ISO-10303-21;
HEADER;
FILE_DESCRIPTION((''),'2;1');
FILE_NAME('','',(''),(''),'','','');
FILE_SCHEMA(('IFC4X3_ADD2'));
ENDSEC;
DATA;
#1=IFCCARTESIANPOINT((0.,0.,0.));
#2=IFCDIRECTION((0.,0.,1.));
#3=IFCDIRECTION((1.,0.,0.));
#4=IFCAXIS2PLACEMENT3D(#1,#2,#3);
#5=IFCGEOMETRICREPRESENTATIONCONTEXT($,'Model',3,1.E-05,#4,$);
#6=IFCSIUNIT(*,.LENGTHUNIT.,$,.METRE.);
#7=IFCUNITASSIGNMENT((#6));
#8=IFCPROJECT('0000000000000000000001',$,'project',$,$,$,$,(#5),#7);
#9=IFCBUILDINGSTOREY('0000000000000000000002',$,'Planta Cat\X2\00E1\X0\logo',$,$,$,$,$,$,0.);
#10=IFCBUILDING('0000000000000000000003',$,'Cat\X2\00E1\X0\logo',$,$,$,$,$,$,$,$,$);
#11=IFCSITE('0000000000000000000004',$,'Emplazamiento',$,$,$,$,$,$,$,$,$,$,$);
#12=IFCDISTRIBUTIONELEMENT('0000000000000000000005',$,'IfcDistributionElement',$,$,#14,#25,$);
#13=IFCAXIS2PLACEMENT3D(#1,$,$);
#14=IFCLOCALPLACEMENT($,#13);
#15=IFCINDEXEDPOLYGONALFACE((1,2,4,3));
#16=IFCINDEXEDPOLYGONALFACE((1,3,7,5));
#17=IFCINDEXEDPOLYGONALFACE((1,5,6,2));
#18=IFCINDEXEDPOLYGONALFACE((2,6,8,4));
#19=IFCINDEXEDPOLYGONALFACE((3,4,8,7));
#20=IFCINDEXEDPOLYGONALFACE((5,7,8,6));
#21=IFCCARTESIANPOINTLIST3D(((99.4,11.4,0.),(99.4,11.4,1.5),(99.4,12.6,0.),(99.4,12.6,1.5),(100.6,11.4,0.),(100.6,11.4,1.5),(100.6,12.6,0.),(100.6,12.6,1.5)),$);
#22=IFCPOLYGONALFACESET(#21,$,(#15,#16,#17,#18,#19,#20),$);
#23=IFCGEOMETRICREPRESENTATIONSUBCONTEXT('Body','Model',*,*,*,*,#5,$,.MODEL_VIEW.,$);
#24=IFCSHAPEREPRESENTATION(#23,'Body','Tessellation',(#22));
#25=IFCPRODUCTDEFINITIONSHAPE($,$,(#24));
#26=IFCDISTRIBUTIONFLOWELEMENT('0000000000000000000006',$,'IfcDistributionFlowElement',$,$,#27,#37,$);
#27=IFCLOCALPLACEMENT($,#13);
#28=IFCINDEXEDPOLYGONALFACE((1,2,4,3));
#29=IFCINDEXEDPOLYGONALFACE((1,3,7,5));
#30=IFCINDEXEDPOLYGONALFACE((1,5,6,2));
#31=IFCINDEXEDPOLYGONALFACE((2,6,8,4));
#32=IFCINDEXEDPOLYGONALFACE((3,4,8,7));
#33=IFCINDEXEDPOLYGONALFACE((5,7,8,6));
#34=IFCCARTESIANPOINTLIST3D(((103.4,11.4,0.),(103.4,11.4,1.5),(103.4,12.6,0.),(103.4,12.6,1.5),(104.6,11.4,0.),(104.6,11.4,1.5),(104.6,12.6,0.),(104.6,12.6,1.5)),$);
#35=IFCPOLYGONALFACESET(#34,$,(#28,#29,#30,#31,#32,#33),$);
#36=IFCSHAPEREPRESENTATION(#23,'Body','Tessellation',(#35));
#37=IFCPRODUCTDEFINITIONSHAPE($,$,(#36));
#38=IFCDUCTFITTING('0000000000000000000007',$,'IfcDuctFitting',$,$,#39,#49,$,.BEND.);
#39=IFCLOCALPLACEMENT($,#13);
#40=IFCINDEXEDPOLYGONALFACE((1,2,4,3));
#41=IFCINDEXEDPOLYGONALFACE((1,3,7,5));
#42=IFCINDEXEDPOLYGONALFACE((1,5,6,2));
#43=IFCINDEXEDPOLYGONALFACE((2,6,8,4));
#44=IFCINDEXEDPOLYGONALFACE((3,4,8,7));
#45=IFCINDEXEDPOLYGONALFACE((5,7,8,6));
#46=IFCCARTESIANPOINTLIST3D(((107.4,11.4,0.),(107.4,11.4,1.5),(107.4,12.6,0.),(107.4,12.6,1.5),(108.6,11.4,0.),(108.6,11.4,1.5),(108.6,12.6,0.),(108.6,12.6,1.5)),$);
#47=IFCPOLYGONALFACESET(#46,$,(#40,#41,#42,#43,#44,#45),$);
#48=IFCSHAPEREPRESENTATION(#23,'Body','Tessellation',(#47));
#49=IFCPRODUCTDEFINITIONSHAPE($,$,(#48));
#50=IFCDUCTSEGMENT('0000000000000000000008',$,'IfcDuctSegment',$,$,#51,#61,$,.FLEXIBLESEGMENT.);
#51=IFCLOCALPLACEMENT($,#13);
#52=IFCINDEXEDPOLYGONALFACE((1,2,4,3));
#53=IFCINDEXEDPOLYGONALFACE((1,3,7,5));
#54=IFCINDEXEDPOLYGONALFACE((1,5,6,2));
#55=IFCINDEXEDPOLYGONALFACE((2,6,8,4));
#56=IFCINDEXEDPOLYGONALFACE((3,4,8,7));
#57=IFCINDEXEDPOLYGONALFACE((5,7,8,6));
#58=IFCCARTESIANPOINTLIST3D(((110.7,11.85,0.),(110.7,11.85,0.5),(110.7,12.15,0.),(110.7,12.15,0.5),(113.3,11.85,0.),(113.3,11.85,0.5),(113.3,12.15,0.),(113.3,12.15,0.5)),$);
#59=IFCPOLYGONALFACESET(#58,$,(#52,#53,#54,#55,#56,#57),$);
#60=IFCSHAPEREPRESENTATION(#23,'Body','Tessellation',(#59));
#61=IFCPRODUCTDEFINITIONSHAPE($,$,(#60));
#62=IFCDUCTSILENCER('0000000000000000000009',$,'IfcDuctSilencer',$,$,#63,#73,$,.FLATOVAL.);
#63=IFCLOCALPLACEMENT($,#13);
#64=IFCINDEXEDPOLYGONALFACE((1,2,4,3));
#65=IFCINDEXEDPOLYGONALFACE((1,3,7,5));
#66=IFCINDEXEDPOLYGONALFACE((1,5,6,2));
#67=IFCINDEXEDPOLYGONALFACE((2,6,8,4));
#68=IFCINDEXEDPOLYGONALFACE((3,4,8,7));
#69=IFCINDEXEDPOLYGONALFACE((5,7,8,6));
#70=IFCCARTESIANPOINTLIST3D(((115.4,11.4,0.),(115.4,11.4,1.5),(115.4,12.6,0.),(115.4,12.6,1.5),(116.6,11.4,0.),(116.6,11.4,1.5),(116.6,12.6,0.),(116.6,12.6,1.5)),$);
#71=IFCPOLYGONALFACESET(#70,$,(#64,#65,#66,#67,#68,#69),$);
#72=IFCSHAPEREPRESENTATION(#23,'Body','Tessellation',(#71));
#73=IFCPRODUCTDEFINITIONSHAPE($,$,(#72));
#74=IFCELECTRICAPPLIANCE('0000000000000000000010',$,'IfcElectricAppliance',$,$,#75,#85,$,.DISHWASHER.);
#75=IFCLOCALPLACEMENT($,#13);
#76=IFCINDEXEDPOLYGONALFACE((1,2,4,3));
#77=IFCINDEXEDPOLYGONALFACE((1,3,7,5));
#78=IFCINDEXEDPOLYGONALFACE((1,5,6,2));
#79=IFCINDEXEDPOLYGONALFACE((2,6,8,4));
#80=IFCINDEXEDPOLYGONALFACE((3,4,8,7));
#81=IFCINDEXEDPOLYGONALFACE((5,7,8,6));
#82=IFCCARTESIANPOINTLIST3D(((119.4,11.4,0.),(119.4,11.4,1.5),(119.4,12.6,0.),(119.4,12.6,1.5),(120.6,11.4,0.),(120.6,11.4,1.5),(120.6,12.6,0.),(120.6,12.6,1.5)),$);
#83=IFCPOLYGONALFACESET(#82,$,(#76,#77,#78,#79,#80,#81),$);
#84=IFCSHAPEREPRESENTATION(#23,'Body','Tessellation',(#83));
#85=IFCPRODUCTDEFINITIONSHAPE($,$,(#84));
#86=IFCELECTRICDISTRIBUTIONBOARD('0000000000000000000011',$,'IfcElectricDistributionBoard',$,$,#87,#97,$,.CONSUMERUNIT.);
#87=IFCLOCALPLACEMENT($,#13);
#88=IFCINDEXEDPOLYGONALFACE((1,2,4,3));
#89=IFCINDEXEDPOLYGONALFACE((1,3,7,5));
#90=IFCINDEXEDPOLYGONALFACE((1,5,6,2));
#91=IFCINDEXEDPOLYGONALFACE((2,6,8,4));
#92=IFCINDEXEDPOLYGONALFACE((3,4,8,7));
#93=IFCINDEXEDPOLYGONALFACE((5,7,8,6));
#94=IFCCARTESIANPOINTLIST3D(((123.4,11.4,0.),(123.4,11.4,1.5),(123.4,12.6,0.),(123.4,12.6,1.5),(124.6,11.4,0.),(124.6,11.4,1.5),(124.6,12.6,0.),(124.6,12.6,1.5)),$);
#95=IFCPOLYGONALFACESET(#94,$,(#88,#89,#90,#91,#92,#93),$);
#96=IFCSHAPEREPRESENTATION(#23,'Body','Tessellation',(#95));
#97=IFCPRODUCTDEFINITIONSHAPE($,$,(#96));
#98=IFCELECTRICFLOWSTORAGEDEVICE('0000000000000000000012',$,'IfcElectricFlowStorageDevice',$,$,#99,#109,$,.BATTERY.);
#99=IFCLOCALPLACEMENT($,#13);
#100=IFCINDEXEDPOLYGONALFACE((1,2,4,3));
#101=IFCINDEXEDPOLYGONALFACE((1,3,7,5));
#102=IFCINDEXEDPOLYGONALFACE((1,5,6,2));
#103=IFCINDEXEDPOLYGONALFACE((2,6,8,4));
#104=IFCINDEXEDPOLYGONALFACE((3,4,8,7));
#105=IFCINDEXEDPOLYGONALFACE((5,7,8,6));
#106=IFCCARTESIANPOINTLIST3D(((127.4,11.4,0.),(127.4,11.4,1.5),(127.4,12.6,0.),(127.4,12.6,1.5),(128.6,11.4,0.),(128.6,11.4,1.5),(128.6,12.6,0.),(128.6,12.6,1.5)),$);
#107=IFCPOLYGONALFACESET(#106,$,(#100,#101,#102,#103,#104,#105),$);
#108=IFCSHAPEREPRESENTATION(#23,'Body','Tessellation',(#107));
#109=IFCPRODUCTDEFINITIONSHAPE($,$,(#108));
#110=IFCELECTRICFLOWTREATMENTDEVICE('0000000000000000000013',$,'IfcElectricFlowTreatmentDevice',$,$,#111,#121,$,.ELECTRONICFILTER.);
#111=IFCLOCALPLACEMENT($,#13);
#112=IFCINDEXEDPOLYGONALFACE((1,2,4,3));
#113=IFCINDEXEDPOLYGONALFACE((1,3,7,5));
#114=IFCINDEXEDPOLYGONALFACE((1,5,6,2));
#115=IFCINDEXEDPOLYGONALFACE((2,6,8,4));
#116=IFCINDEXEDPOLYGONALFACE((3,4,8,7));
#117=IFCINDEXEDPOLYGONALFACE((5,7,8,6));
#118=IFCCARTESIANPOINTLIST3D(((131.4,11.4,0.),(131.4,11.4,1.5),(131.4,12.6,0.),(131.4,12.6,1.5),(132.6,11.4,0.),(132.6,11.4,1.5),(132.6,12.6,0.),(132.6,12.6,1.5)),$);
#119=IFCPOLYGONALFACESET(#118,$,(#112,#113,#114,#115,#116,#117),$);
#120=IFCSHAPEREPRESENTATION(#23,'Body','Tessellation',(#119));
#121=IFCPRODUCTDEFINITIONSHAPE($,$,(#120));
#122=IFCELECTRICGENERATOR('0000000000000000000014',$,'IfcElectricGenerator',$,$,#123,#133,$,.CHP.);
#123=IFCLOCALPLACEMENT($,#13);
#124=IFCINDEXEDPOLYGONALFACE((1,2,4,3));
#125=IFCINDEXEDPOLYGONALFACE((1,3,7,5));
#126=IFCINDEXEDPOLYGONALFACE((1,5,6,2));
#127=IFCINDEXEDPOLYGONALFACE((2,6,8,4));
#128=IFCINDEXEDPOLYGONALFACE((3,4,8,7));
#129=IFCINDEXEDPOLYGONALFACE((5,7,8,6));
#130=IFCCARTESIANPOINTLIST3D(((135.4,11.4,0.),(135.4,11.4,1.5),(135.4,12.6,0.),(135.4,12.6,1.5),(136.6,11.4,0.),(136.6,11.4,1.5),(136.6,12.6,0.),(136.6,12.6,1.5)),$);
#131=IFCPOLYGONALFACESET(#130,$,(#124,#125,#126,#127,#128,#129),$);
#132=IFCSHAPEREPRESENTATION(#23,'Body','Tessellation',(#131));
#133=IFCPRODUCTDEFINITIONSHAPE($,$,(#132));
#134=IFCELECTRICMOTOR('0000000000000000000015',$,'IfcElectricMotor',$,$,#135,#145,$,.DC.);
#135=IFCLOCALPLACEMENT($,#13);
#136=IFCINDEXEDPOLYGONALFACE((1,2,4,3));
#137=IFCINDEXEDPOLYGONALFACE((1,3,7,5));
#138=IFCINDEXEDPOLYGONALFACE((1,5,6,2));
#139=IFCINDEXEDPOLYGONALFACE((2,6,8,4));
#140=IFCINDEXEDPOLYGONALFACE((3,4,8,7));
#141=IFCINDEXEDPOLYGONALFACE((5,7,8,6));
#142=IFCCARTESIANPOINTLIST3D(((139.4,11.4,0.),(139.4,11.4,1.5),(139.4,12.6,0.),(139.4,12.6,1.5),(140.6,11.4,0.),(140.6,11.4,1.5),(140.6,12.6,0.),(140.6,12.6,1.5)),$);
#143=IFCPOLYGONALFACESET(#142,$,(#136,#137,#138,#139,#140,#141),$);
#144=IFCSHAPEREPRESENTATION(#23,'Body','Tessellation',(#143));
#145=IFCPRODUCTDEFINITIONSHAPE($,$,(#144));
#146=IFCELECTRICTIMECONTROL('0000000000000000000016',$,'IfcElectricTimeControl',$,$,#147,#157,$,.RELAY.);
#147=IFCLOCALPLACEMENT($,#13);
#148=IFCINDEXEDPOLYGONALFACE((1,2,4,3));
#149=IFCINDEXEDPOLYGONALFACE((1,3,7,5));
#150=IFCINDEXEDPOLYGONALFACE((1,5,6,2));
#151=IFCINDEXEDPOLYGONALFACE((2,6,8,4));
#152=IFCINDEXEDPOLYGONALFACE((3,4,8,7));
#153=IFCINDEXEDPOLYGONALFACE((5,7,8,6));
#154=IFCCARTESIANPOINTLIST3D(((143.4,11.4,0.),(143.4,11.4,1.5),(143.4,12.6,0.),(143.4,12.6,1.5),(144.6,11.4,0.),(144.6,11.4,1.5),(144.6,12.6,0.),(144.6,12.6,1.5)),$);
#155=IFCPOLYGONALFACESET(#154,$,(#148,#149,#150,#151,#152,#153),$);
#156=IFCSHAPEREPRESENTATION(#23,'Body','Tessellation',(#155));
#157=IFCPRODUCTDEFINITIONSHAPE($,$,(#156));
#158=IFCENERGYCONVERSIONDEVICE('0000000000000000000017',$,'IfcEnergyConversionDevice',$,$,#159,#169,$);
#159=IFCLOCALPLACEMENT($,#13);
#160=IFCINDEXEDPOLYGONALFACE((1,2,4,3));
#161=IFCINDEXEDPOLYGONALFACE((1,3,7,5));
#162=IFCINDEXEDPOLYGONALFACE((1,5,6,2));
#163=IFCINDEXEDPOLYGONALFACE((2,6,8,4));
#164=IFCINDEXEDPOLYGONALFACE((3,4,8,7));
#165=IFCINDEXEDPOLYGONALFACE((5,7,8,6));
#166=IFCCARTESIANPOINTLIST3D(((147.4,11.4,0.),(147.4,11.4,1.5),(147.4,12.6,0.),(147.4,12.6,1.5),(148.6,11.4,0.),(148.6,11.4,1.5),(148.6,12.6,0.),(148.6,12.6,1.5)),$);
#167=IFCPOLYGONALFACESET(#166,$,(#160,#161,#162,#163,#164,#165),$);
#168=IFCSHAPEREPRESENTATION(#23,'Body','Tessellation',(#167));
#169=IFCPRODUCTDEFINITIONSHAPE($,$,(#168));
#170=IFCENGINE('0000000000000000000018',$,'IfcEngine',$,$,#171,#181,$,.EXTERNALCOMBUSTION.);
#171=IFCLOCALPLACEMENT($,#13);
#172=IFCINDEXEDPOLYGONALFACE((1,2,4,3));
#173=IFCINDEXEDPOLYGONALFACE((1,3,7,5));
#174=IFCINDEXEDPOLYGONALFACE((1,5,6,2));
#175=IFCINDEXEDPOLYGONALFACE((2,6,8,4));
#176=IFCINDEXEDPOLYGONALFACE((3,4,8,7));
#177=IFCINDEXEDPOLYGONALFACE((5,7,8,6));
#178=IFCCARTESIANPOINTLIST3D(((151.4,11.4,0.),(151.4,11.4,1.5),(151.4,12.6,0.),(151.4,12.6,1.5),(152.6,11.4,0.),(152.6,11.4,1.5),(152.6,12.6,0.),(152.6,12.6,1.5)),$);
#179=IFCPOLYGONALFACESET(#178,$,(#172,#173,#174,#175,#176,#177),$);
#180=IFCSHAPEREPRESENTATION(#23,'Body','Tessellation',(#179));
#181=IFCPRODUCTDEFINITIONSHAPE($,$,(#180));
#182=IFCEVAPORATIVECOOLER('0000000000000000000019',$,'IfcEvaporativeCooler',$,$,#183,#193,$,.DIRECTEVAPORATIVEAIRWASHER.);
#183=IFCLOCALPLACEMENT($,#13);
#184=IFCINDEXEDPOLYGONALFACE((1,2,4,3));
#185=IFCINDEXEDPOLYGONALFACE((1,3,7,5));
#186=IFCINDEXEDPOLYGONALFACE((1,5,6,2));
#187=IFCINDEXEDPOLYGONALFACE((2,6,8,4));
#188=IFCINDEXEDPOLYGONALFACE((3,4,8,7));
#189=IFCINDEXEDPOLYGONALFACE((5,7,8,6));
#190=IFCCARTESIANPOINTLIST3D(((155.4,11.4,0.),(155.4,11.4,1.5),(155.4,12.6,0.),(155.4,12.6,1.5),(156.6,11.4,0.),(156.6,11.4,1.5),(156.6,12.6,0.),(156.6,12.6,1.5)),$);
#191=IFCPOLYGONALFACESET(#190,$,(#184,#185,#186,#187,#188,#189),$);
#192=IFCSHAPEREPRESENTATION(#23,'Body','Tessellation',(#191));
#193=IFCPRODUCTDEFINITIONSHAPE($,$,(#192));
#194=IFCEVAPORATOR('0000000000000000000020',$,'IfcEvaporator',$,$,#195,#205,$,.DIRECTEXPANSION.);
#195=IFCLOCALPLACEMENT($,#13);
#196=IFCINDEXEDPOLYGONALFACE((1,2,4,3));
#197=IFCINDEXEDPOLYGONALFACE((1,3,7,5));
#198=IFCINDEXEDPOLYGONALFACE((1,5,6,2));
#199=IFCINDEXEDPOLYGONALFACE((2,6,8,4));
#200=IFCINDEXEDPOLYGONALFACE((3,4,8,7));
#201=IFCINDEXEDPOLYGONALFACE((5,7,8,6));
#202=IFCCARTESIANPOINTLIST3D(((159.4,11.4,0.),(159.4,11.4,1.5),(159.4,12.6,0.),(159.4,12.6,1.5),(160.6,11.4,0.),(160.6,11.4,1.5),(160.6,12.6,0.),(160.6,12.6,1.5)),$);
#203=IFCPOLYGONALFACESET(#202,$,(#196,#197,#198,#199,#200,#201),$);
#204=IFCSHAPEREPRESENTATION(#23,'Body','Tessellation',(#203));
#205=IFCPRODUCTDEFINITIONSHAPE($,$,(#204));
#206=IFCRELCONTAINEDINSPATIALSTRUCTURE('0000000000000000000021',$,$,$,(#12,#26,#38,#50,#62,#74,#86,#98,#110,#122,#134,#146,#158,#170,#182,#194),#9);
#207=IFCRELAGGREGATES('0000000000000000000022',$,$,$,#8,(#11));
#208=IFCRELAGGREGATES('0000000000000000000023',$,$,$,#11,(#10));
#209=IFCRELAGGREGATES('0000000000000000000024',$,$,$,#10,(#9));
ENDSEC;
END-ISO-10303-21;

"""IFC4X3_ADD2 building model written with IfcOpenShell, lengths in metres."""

from ifc_helpers import new_model, si_unit, frame, origin, origin_with_axes, origin_2d, place, context, subcontext, project, spatial, rectangle, extrude, element, save


model = new_model("IFC4X3_ADD2")

# Units and contexts
model_context = context("Model", 3, precision=1e-05, world=origin_with_axes())
body_context = subcontext(model_context, "Body", "Model", "MODEL_VIEW")
ifc_project = project(units=[si_unit("LENGTHUNIT", "METRE")], contexts=[model_context])

# Site, building, storey
site = spatial("IfcSite", under=ifc_project, Name="Emplazamiento")
building = spatial("IfcBuilding", under=site, Name="Catálogo")
storey = spatial("IfcBuildingStorey", under=building, Name="Planta Catálogo", Elevation=0.0)

# Distribution element
distribution_element_placement = place(None, frame((100.0, 12.0, 0.0), z_axis=(0.0, 0.0, 1.0), x_axis=(1.0, 0.0, 0.0)))
element("IfcDistributionElement", 1, at=distribution_element_placement, inside=storey, Name="IfcDistributionElement", context=body_context, shape_type="SweptSolid", body=[
    extrude(rectangle(XDim=1.2, YDim=1.2, at=origin_2d()), origin(), (0.0, 0.0, 1.0), 1.5),
])

# Distribution flow element
distribution_flow_element_placement = place(None, frame((104.0, 12.0, 0.0), z_axis=(0.0, 0.0, 1.0), x_axis=(1.0, 0.0, 0.0)))
element("IfcDistributionFlowElement", 2, at=distribution_flow_element_placement, inside=storey, Name="IfcDistributionFlowElement", context=body_context, shape_type="SweptSolid", body=[
    extrude(rectangle(XDim=1.2, YDim=1.2, at=origin_2d()), origin(), (0.0, 0.0, 1.0), 1.5),
])

# Duct fitting
duct_fitting_placement = place(None, frame((108.0, 12.0, 0.0), z_axis=(0.0, 0.0, 1.0), x_axis=(1.0, 0.0, 0.0)))
element("IfcDuctFitting", 3, at=duct_fitting_placement, inside=storey, Name="IfcDuctFitting", PredefinedType="BEND", context=body_context, shape_type="SweptSolid", body=[
    extrude(rectangle(XDim=1.2, YDim=1.2, at=origin_2d()), origin(), (0.0, 0.0, 1.0), 1.5),
])

# Duct segment
duct_segment_placement = place(None, frame((112.0, 12.0, 0.0), z_axis=(0.0, 0.0, 1.0), x_axis=(1.0, 0.0, 0.0)))
element("IfcDuctSegment", 4, at=duct_segment_placement, inside=storey, Name="IfcDuctSegment", PredefinedType="FLEXIBLESEGMENT", context=body_context, shape_type="SweptSolid", body=[
    extrude(rectangle(XDim=2.6, YDim=0.3, at=origin_2d()), origin(), (0.0, 0.0, 1.0), 0.5),
])

# Duct silencer
duct_silencer_placement = place(None, frame((116.0, 12.0, 0.0), z_axis=(0.0, 0.0, 1.0), x_axis=(1.0, 0.0, 0.0)))
element("IfcDuctSilencer", 5, at=duct_silencer_placement, inside=storey, Name="IfcDuctSilencer", PredefinedType="FLATOVAL", context=body_context, shape_type="SweptSolid", body=[
    extrude(rectangle(XDim=1.2, YDim=1.2, at=origin_2d()), origin(), (0.0, 0.0, 1.0), 1.5),
])

# Electric appliance
electric_appliance_placement = place(None, frame((120.0, 12.0, 0.0), z_axis=(0.0, 0.0, 1.0), x_axis=(1.0, 0.0, 0.0)))
element("IfcElectricAppliance", 6, at=electric_appliance_placement, inside=storey, Name="IfcElectricAppliance", PredefinedType="DISHWASHER", context=body_context, shape_type="SweptSolid", body=[
    extrude(rectangle(XDim=1.2, YDim=1.2, at=origin_2d()), origin(), (0.0, 0.0, 1.0), 1.5),
])

# Electric distribution board
electric_distribution_board_placement = place(None, frame((124.0, 12.0, 0.0), z_axis=(0.0, 0.0, 1.0), x_axis=(1.0, 0.0, 0.0)))
element("IfcElectricDistributionBoard", 7, at=electric_distribution_board_placement, inside=storey, Name="IfcElectricDistributionBoard", PredefinedType="CONSUMERUNIT", context=body_context, shape_type="SweptSolid", body=[
    extrude(rectangle(XDim=1.2, YDim=1.2, at=origin_2d()), origin(), (0.0, 0.0, 1.0), 1.5),
])

# Electric flow storage device
electric_flow_storage_device_placement = place(None, frame((128.0, 12.0, 0.0), z_axis=(0.0, 0.0, 1.0), x_axis=(1.0, 0.0, 0.0)))
element("IfcElectricFlowStorageDevice", 8, at=electric_flow_storage_device_placement, inside=storey, Name="IfcElectricFlowStorageDevice", PredefinedType="BATTERY", context=body_context, shape_type="SweptSolid", body=[
    extrude(rectangle(XDim=1.2, YDim=1.2, at=origin_2d()), origin(), (0.0, 0.0, 1.0), 1.5),
])

# Electric flow treatment device
electric_flow_treatment_device_placement = place(None, frame((132.0, 12.0, 0.0), z_axis=(0.0, 0.0, 1.0), x_axis=(1.0, 0.0, 0.0)))
element("IfcElectricFlowTreatmentDevice", 9, at=electric_flow_treatment_device_placement, inside=storey, Name="IfcElectricFlowTreatmentDevice", PredefinedType="ELECTRONICFILTER", context=body_context, shape_type="SweptSolid", body=[
    extrude(rectangle(XDim=1.2, YDim=1.2, at=origin_2d()), origin(), (0.0, 0.0, 1.0), 1.5),
])

# Electric generator
electric_generator_placement = place(None, frame((136.0, 12.0, 0.0), z_axis=(0.0, 0.0, 1.0), x_axis=(1.0, 0.0, 0.0)))
element("IfcElectricGenerator", 10, at=electric_generator_placement, inside=storey, Name="IfcElectricGenerator", PredefinedType="CHP", context=body_context, shape_type="SweptSolid", body=[
    extrude(rectangle(XDim=1.2, YDim=1.2, at=origin_2d()), origin(), (0.0, 0.0, 1.0), 1.5),
])

# Electric motor
electric_motor_placement = place(None, frame((140.0, 12.0, 0.0), z_axis=(0.0, 0.0, 1.0), x_axis=(1.0, 0.0, 0.0)))
element("IfcElectricMotor", 11, at=electric_motor_placement, inside=storey, Name="IfcElectricMotor", PredefinedType="DC", context=body_context, shape_type="SweptSolid", body=[
    extrude(rectangle(XDim=1.2, YDim=1.2, at=origin_2d()), origin(), (0.0, 0.0, 1.0), 1.5),
])

# Electric time control
electric_time_control_placement = place(None, frame((144.0, 12.0, 0.0), z_axis=(0.0, 0.0, 1.0), x_axis=(1.0, 0.0, 0.0)))
element("IfcElectricTimeControl", 12, at=electric_time_control_placement, inside=storey, Name="IfcElectricTimeControl", PredefinedType="RELAY", context=body_context, shape_type="SweptSolid", body=[
    extrude(rectangle(XDim=1.2, YDim=1.2, at=origin_2d()), origin(), (0.0, 0.0, 1.0), 1.5),
])

# Energy conversion device
energy_conversion_device_placement = place(None, frame((148.0, 12.0, 0.0), z_axis=(0.0, 0.0, 1.0), x_axis=(1.0, 0.0, 0.0)))
element("IfcEnergyConversionDevice", 13, at=energy_conversion_device_placement, inside=storey, Name="IfcEnergyConversionDevice", context=body_context, shape_type="SweptSolid", body=[
    extrude(rectangle(XDim=1.2, YDim=1.2, at=origin_2d()), origin(), (0.0, 0.0, 1.0), 1.5),
])

# Engine
engine_placement = place(None, frame((152.0, 12.0, 0.0), z_axis=(0.0, 0.0, 1.0), x_axis=(1.0, 0.0, 0.0)))
element("IfcEngine", 14, at=engine_placement, inside=storey, Name="IfcEngine", PredefinedType="EXTERNALCOMBUSTION", context=body_context, shape_type="SweptSolid", body=[
    extrude(rectangle(XDim=1.2, YDim=1.2, at=origin_2d()), origin(), (0.0, 0.0, 1.0), 1.5),
])

# Evaporative cooler
evaporative_cooler_placement = place(None, frame((156.0, 12.0, 0.0), z_axis=(0.0, 0.0, 1.0), x_axis=(1.0, 0.0, 0.0)))
element("IfcEvaporativeCooler", 15, at=evaporative_cooler_placement, inside=storey, Name="IfcEvaporativeCooler", PredefinedType="DIRECTEVAPORATIVEAIRWASHER", context=body_context, shape_type="SweptSolid", body=[
    extrude(rectangle(XDim=1.2, YDim=1.2, at=origin_2d()), origin(), (0.0, 0.0, 1.0), 1.5),
])

# Evaporator
evaporator_placement = place(None, frame((160.0, 12.0, 0.0), z_axis=(0.0, 0.0, 1.0), x_axis=(1.0, 0.0, 0.0)))
element("IfcEvaporator", 16, at=evaporator_placement, inside=storey, Name="IfcEvaporator", PredefinedType="DIRECTEXPANSION", context=body_context, shape_type="SweptSolid", body=[
    extrude(rectangle(XDim=1.2, YDim=1.2, at=origin_2d()), origin(), (0.0, 0.0, 1.0), 1.5),
])

save(model, "model.ifc")
